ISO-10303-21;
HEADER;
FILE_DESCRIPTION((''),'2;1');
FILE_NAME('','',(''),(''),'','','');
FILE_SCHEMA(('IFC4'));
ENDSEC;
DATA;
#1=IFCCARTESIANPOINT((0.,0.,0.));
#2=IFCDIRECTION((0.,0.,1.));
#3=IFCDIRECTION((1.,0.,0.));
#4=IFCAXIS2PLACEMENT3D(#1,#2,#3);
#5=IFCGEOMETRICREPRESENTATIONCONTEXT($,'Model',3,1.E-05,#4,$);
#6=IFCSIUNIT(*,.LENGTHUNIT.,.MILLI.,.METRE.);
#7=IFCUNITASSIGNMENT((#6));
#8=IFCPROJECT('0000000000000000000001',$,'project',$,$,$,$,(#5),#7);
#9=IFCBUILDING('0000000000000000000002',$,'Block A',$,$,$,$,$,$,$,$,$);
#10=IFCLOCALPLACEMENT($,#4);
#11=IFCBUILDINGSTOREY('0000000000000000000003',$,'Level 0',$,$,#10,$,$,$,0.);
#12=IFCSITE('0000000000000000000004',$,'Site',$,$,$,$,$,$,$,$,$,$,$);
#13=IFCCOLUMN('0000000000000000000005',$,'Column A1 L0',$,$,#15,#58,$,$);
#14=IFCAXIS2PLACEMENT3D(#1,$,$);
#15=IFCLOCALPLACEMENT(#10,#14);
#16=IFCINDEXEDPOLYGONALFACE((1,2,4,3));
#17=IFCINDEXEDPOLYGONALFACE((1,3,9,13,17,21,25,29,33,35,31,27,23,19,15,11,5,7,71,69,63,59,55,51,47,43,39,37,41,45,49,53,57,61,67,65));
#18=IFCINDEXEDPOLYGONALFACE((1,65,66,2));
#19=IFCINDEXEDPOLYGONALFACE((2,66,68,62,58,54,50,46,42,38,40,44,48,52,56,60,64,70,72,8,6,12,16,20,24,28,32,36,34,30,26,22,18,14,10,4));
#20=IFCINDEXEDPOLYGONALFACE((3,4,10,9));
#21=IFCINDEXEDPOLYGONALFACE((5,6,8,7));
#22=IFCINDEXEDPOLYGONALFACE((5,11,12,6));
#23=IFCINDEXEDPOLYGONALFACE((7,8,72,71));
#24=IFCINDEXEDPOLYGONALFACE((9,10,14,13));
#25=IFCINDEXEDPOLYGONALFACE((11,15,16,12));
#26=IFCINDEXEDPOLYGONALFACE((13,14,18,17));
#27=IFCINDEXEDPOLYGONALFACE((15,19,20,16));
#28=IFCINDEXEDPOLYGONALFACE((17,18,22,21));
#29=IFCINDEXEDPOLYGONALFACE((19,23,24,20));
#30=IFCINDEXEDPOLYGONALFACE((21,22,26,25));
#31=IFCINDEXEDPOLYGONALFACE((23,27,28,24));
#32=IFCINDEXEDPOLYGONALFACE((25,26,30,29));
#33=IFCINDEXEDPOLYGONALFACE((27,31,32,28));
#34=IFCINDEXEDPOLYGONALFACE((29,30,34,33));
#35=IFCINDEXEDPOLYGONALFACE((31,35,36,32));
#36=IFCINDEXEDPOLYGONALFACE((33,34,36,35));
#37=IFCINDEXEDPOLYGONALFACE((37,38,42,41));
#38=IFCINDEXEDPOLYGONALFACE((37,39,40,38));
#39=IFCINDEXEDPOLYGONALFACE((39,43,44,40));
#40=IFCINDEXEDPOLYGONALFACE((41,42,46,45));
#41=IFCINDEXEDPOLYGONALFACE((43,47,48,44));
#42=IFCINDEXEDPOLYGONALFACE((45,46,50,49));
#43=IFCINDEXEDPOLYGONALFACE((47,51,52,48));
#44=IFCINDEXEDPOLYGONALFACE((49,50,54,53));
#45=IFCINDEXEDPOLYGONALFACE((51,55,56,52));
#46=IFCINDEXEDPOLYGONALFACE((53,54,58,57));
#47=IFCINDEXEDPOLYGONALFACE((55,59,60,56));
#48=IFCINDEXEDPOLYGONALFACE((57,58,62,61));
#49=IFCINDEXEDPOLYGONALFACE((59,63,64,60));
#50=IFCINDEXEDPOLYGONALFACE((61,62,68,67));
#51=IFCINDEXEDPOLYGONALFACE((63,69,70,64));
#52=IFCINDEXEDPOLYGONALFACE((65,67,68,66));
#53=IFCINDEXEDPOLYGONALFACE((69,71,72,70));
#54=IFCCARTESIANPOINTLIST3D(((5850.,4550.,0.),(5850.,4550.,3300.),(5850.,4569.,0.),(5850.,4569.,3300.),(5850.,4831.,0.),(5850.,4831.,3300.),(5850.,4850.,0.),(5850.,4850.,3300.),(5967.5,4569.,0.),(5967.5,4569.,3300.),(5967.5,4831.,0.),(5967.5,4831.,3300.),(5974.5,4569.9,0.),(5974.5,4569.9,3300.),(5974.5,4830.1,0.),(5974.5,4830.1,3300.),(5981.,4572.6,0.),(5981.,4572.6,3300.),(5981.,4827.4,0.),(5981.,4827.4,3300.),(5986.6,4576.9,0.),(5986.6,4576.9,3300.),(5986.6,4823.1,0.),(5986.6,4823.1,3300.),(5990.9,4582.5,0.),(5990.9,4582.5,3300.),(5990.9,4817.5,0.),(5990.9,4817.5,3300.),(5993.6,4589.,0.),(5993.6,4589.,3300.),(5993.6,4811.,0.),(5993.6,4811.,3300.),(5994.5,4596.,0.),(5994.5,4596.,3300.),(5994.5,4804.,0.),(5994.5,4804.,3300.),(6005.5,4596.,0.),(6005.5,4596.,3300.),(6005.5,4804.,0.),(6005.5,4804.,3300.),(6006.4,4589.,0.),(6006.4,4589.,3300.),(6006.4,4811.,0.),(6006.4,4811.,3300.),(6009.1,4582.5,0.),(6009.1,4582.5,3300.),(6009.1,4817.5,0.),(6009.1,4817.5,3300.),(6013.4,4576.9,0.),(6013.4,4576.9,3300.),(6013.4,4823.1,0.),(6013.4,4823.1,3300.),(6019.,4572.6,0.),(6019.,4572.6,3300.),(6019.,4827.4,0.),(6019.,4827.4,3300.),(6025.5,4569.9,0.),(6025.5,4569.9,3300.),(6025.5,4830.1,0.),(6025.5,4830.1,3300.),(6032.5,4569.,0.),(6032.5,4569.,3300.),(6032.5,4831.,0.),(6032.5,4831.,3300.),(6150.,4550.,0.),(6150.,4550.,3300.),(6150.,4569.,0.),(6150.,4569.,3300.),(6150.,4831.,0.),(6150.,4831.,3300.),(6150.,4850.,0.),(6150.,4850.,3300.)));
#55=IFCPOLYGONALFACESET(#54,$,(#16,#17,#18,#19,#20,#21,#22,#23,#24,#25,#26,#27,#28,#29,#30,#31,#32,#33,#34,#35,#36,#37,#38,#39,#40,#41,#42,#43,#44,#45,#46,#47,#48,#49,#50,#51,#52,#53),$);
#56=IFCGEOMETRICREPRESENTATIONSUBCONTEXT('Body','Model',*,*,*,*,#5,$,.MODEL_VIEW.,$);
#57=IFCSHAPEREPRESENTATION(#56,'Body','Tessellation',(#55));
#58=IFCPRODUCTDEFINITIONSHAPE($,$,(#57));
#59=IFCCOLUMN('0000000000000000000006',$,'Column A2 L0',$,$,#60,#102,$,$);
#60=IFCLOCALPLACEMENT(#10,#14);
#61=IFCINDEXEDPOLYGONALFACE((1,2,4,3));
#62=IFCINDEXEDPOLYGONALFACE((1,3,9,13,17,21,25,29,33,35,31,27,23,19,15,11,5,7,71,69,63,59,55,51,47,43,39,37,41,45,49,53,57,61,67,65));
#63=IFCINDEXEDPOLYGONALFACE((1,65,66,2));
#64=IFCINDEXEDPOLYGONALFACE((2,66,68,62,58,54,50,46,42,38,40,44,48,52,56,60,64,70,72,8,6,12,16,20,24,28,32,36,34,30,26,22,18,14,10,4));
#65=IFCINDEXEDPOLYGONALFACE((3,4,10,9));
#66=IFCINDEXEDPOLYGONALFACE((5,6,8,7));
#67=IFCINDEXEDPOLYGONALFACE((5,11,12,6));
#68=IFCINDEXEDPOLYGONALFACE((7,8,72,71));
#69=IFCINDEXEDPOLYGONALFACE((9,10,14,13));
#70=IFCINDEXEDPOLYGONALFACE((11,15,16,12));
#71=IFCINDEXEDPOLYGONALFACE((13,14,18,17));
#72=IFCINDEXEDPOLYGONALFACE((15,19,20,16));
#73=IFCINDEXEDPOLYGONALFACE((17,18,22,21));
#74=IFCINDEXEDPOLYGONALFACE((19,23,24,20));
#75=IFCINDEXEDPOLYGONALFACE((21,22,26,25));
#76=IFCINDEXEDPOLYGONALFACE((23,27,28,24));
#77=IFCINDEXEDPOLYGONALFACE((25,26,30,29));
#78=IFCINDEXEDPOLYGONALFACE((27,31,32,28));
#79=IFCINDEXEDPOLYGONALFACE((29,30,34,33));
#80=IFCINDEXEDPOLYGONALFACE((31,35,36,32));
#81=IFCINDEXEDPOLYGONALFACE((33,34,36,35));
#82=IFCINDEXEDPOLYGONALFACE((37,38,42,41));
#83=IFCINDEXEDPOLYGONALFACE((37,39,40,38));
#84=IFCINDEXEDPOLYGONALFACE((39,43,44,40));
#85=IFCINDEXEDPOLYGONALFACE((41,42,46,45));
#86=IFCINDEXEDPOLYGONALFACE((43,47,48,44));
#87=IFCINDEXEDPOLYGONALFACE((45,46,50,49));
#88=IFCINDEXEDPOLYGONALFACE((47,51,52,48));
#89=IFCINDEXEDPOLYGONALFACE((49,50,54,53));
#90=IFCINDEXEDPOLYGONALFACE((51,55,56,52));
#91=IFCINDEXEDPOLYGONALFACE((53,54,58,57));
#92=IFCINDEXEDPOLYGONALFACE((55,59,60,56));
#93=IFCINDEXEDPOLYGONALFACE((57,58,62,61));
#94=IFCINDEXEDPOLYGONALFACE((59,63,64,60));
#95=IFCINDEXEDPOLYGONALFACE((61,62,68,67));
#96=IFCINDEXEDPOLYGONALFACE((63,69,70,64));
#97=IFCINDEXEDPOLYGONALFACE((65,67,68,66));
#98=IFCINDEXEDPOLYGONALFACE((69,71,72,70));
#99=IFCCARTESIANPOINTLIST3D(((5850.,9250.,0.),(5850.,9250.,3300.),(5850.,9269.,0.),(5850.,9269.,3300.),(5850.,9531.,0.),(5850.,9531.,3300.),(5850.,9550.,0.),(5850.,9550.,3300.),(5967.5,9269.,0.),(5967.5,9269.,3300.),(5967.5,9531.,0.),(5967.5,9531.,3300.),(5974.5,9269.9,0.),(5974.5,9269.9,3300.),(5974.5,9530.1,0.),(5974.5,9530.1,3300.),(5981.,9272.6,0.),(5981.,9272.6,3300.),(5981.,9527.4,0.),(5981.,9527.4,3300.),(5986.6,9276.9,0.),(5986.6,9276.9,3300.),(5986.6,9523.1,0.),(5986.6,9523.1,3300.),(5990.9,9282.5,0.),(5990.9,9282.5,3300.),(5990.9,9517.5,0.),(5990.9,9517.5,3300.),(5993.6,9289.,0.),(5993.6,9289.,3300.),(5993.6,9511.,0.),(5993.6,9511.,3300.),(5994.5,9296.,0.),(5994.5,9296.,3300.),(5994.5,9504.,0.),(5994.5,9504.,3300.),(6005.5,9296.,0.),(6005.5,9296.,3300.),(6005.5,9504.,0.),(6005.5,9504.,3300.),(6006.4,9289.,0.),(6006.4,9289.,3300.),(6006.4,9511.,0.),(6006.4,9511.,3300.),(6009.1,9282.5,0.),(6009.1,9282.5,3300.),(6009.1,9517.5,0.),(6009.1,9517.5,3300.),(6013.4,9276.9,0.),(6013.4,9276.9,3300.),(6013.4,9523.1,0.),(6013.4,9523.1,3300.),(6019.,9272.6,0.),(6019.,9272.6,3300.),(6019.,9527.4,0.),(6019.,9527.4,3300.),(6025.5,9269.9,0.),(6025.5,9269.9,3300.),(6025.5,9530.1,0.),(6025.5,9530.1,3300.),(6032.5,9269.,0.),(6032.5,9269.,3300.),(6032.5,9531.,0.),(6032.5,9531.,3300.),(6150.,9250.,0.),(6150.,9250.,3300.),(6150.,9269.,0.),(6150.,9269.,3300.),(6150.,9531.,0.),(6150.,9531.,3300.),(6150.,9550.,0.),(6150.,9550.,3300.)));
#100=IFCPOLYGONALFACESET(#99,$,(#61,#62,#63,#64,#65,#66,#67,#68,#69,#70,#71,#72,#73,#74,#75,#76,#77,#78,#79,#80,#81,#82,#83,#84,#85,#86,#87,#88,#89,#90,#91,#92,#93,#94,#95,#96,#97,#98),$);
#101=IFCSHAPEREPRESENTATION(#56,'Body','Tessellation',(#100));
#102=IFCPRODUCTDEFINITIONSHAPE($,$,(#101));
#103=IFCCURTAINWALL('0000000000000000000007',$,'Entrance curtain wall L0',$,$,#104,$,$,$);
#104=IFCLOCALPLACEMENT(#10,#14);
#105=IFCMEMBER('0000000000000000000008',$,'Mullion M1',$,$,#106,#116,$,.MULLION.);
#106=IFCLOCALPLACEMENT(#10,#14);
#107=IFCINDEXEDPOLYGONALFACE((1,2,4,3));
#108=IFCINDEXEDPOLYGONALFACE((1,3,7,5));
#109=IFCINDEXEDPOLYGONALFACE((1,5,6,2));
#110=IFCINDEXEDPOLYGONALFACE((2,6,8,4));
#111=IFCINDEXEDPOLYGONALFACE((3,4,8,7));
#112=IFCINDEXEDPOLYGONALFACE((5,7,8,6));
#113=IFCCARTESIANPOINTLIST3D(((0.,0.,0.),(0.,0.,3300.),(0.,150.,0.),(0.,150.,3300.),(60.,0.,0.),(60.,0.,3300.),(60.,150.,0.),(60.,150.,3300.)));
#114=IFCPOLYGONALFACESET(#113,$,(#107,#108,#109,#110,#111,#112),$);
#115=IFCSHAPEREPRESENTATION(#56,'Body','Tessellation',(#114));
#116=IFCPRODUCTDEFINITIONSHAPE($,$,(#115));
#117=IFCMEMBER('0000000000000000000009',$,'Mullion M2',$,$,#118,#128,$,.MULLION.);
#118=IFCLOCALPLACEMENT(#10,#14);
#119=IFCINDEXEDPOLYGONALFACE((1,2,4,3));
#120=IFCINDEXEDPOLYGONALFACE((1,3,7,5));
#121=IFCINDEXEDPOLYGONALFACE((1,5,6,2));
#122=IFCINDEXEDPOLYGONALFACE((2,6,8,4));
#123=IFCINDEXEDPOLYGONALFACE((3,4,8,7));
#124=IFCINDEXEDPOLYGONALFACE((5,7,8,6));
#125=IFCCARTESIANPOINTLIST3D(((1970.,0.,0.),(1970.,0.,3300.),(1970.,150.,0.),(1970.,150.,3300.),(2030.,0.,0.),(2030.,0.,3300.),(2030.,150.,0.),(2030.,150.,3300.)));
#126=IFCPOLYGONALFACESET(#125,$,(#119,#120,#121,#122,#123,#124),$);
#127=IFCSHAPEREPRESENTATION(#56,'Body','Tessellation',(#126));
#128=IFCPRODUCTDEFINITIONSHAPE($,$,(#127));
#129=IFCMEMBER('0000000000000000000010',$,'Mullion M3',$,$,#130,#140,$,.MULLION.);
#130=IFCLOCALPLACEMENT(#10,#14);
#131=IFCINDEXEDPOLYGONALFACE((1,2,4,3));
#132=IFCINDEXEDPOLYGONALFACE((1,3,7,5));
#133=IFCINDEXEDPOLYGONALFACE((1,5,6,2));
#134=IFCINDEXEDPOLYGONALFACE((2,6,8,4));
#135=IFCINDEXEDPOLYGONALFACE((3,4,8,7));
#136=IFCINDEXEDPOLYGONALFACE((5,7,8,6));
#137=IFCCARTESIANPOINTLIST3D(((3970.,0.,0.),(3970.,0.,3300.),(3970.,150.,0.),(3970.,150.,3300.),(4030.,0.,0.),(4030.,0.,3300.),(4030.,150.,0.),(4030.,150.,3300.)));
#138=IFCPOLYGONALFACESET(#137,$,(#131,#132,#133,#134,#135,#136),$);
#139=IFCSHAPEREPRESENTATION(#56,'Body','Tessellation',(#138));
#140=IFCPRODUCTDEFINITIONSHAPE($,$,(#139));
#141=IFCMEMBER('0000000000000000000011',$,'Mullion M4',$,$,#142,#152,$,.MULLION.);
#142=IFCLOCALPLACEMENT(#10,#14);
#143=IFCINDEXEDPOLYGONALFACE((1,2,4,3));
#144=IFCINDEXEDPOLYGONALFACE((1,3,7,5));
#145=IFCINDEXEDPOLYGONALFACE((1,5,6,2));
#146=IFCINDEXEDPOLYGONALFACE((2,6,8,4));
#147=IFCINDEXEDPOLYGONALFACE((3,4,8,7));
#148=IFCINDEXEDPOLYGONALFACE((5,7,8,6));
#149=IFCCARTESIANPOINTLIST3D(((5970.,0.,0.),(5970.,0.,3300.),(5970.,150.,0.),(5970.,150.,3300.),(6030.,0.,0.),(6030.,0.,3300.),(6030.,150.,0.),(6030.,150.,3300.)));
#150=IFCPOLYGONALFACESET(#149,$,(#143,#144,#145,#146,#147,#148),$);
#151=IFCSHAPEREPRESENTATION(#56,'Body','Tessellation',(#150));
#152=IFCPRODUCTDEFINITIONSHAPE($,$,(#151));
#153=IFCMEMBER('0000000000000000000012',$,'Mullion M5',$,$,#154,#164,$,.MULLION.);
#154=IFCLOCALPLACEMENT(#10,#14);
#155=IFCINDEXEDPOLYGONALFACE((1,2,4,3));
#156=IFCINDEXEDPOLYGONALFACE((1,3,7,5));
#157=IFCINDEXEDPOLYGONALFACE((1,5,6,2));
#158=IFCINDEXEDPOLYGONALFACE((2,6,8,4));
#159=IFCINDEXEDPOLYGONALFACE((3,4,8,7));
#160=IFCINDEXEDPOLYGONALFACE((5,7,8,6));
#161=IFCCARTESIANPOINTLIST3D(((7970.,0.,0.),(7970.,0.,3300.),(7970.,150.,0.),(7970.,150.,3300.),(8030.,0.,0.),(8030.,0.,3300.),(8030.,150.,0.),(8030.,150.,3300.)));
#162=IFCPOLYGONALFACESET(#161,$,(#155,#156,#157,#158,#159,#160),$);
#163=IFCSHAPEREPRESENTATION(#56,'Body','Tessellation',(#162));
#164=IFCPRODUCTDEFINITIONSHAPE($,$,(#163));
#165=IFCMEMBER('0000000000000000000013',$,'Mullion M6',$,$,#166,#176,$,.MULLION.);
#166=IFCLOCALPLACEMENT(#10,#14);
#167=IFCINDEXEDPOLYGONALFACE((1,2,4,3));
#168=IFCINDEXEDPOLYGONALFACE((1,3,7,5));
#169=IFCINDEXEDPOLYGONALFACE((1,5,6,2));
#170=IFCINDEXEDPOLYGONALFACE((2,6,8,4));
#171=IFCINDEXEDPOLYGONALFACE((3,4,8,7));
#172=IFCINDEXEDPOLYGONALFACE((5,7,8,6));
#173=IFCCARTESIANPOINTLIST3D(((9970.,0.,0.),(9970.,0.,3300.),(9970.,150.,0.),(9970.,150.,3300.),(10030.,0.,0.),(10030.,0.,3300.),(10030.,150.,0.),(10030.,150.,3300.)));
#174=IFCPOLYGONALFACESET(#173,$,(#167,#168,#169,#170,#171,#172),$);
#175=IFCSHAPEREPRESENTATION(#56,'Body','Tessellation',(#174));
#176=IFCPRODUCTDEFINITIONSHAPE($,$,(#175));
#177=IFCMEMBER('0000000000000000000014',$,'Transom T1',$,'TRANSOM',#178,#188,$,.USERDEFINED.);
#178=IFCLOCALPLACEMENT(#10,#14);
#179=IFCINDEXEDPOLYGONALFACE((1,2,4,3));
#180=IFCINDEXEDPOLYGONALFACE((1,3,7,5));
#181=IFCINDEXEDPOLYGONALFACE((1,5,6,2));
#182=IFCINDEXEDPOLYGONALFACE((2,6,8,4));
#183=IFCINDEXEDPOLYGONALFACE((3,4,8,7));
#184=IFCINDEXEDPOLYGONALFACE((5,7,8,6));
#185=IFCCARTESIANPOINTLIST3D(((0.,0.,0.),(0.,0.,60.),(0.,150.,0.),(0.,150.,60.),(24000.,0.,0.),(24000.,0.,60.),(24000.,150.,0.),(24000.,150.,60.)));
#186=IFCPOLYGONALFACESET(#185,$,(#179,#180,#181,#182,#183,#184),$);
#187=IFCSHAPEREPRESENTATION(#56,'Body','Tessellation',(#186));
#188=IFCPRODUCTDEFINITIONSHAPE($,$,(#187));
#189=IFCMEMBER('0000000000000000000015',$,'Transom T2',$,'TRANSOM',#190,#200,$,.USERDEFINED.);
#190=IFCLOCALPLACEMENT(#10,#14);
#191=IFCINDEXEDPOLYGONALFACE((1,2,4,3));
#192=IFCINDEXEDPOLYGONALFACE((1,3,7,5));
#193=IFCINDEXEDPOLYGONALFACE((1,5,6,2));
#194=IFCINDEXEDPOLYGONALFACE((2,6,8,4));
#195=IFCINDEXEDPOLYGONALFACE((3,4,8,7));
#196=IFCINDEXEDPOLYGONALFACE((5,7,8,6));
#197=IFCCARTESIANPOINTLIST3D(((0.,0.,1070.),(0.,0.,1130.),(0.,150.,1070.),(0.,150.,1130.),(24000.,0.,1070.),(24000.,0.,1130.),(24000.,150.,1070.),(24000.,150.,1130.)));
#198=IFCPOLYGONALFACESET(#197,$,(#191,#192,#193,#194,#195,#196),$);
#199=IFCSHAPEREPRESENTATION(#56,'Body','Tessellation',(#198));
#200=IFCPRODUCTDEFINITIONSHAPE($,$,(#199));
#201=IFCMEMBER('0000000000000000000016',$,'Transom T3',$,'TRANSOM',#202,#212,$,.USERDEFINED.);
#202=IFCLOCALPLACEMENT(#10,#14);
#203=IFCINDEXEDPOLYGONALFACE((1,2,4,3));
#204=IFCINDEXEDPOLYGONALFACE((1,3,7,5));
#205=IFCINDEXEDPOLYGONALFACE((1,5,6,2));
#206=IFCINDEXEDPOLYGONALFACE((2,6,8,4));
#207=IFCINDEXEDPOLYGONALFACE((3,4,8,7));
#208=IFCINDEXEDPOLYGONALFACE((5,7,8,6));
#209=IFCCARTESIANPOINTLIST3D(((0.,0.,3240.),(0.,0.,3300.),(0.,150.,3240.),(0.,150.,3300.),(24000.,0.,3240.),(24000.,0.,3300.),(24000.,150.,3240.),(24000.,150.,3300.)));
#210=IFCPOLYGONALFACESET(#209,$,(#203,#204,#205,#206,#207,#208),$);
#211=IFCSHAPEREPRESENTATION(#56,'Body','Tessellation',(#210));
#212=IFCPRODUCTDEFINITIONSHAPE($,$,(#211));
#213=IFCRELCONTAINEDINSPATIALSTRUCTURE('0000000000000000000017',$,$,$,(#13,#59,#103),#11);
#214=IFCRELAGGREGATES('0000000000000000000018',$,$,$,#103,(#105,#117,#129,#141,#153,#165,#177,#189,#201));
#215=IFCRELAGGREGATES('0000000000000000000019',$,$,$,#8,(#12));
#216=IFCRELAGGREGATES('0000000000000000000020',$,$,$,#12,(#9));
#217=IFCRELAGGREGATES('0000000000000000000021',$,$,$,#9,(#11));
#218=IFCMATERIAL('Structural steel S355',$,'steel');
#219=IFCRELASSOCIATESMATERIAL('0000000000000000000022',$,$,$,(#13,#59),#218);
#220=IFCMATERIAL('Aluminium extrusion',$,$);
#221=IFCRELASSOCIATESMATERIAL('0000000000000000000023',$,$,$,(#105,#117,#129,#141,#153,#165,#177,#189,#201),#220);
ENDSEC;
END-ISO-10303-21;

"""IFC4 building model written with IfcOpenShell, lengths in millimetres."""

from ifc_helpers import new_model, si_unit, frame, origin_with_axes, place, context, subcontext, project, spatial, rectangle, i_section, extrude, material, material_profile, profile_set, element, aggregate, save


model = new_model("IFC4")

# Units and contexts
model_context = context("Model", 3, precision=1e-05, world=origin_with_axes())
body_context = subcontext(model_context, "Body", "Model", "MODEL_VIEW")
ifc_project = project(units=[si_unit("LENGTHUNIT", "METRE", prefix="MILLI")], contexts=[model_context])

# Site, building, storey
site = spatial("IfcSite", under=ifc_project, Name="Site")
building = spatial("IfcBuilding", under=site, Name="Block A")
storey_placement = place(None, origin_with_axes())
storey = spatial("IfcBuildingStorey", under=building, at=storey_placement, Name="Level 0", Elevation=0.0)

# Columns
ifc_material_1 = material(Name="Structural steel S355", Category="steel")
ifc_material_profile_1 = material_profile(ifc_material_1, i_section(OverallWidth=300.0, OverallDepth=300.0, WebThickness=11.0, FlangeThickness=19.0, FilletRadius=27.0))
ifc_profile_set_1 = profile_set([ifc_material_profile_1], Name="HEB 300")
for number, where, z_axis, x_axis, name in (
    (1, (6000.0, 4700.0, 0.0), (0.0, 0.0, 1.0), (1.0, 0.0, 0.0), "Column A1 L0"),
    (2, (6000.0, 9400.0, 0.0), (0.0, 0.0, 1.0), (1.0, 0.0, 0.0), "Column A2 L0"),
):
    element("IfcColumn", number, at=place(storey_placement, frame(where, z_axis=z_axis, x_axis=x_axis)), inside=storey, material=ifc_profile_set_1, Name=name, context=body_context, shape_type="SweptSolid", body=[
        extrude(i_section(OverallWidth=300.0, OverallDepth=300.0, WebThickness=11.0, FlangeThickness=19.0, FilletRadius=27.0), origin_with_axes(), (0.0, 0.0, 1.0), 3300.0),
    ])

# Curtain wall, members
curtain_wall_placement = place(storey_placement, origin_with_axes())
curtain_wall = element("IfcCurtainWall", 3, at=curtain_wall_placement, inside=storey, Name="Entrance curtain wall L0")
ifc_material_2 = material(Name="Aluminium extrusion")
member_1_placement = place(curtain_wall_placement, frame((30.0, 75.0, 0.0), z_axis=(0.0, 0.0, 1.0), x_axis=(1.0, 0.0, 0.0)))
member_1 = element("IfcMember", 4, at=member_1_placement, material=ifc_material_2, Name="Mullion M1", PredefinedType="MULLION", context=body_context, shape_type="SweptSolid", body=[
    extrude(rectangle(XDim=60.0, YDim=150.0), origin_with_axes(), (0.0, 0.0, 1.0), 3300.0),
])
member_2_placement = place(curtain_wall_placement, frame((2000.0, 75.0, 0.0), z_axis=(0.0, 0.0, 1.0), x_axis=(1.0, 0.0, 0.0)))
member_2 = element("IfcMember", 5, at=member_2_placement, material=ifc_material_2, Name="Mullion M2", PredefinedType="MULLION", context=body_context, shape_type="SweptSolid", body=[
    extrude(rectangle(XDim=60.0, YDim=150.0), origin_with_axes(), (0.0, 0.0, 1.0), 3300.0),
])
member_3_placement = place(curtain_wall_placement, frame((4000.0, 75.0, 0.0), z_axis=(0.0, 0.0, 1.0), x_axis=(1.0, 0.0, 0.0)))
member_3 = element("IfcMember", 6, at=member_3_placement, material=ifc_material_2, Name="Mullion M3", PredefinedType="MULLION", context=body_context, shape_type="SweptSolid", body=[
    extrude(rectangle(XDim=60.0, YDim=150.0), origin_with_axes(), (0.0, 0.0, 1.0), 3300.0),
])
member_4_placement = place(curtain_wall_placement, frame((6000.0, 75.0, 0.0), z_axis=(0.0, 0.0, 1.0), x_axis=(1.0, 0.0, 0.0)))
member_4 = element("IfcMember", 7, at=member_4_placement, material=ifc_material_2, Name="Mullion M4", PredefinedType="MULLION", context=body_context, shape_type="SweptSolid", body=[
    extrude(rectangle(XDim=60.0, YDim=150.0), origin_with_axes(), (0.0, 0.0, 1.0), 3300.0),
])
member_5_placement = place(curtain_wall_placement, frame((8000.0, 75.0, 0.0), z_axis=(0.0, 0.0, 1.0), x_axis=(1.0, 0.0, 0.0)))
member_5 = element("IfcMember", 8, at=member_5_placement, material=ifc_material_2, Name="Mullion M5", PredefinedType="MULLION", context=body_context, shape_type="SweptSolid", body=[
    extrude(rectangle(XDim=60.0, YDim=150.0), origin_with_axes(), (0.0, 0.0, 1.0), 3300.0),
])
member_6_placement = place(curtain_wall_placement, frame((10000.0, 75.0, 0.0), z_axis=(0.0, 0.0, 1.0), x_axis=(1.0, 0.0, 0.0)))
member_6 = element("IfcMember", 9, at=member_6_placement, material=ifc_material_2, Name="Mullion M6", PredefinedType="MULLION", context=body_context, shape_type="SweptSolid", body=[
    extrude(rectangle(XDim=60.0, YDim=150.0), origin_with_axes(), (0.0, 0.0, 1.0), 3300.0),
])
member_7_placement = place(curtain_wall_placement, frame((0.0, 75.0, 30.0), z_axis=(1.0, 0.0, 0.0), x_axis=(0.0, 0.0, -1.0)))
member_7 = element("IfcMember", 10, at=member_7_placement, material=ifc_material_2, Name="Transom T1", ObjectType="TRANSOM", PredefinedType="USERDEFINED", context=body_context, shape_type="SweptSolid", body=[
    extrude(rectangle(XDim=60.0, YDim=150.0), origin_with_axes(), (0.0, 0.0, 1.0), 24000.0),
])
member_8_placement = place(curtain_wall_placement, frame((0.0, 75.0, 1100.0), z_axis=(1.0, 0.0, 0.0), x_axis=(0.0, 0.0, -1.0)))
member_8 = element("IfcMember", 11, at=member_8_placement, material=ifc_material_2, Name="Transom T2", ObjectType="TRANSOM", PredefinedType="USERDEFINED", context=body_context, shape_type="SweptSolid", body=[
    extrude(rectangle(XDim=60.0, YDim=150.0), origin_with_axes(), (0.0, 0.0, 1.0), 24000.0),
])
member_9_placement = place(curtain_wall_placement, frame((0.0, 75.0, 3270.0), z_axis=(1.0, 0.0, 0.0), x_axis=(0.0, 0.0, -1.0)))
member_9 = element("IfcMember", 12, at=member_9_placement, material=ifc_material_2, Name="Transom T3", ObjectType="TRANSOM", PredefinedType="USERDEFINED", context=body_context, shape_type="SweptSolid", body=[
    extrude(rectangle(XDim=60.0, YDim=150.0), origin_with_axes(), (0.0, 0.0, 1.0), 24000.0),
])

aggregate(curtain_wall, [member_1, member_2, member_3, member_4, member_5, member_6, member_7, member_8, member_9])

save(model, "model.ifc")
